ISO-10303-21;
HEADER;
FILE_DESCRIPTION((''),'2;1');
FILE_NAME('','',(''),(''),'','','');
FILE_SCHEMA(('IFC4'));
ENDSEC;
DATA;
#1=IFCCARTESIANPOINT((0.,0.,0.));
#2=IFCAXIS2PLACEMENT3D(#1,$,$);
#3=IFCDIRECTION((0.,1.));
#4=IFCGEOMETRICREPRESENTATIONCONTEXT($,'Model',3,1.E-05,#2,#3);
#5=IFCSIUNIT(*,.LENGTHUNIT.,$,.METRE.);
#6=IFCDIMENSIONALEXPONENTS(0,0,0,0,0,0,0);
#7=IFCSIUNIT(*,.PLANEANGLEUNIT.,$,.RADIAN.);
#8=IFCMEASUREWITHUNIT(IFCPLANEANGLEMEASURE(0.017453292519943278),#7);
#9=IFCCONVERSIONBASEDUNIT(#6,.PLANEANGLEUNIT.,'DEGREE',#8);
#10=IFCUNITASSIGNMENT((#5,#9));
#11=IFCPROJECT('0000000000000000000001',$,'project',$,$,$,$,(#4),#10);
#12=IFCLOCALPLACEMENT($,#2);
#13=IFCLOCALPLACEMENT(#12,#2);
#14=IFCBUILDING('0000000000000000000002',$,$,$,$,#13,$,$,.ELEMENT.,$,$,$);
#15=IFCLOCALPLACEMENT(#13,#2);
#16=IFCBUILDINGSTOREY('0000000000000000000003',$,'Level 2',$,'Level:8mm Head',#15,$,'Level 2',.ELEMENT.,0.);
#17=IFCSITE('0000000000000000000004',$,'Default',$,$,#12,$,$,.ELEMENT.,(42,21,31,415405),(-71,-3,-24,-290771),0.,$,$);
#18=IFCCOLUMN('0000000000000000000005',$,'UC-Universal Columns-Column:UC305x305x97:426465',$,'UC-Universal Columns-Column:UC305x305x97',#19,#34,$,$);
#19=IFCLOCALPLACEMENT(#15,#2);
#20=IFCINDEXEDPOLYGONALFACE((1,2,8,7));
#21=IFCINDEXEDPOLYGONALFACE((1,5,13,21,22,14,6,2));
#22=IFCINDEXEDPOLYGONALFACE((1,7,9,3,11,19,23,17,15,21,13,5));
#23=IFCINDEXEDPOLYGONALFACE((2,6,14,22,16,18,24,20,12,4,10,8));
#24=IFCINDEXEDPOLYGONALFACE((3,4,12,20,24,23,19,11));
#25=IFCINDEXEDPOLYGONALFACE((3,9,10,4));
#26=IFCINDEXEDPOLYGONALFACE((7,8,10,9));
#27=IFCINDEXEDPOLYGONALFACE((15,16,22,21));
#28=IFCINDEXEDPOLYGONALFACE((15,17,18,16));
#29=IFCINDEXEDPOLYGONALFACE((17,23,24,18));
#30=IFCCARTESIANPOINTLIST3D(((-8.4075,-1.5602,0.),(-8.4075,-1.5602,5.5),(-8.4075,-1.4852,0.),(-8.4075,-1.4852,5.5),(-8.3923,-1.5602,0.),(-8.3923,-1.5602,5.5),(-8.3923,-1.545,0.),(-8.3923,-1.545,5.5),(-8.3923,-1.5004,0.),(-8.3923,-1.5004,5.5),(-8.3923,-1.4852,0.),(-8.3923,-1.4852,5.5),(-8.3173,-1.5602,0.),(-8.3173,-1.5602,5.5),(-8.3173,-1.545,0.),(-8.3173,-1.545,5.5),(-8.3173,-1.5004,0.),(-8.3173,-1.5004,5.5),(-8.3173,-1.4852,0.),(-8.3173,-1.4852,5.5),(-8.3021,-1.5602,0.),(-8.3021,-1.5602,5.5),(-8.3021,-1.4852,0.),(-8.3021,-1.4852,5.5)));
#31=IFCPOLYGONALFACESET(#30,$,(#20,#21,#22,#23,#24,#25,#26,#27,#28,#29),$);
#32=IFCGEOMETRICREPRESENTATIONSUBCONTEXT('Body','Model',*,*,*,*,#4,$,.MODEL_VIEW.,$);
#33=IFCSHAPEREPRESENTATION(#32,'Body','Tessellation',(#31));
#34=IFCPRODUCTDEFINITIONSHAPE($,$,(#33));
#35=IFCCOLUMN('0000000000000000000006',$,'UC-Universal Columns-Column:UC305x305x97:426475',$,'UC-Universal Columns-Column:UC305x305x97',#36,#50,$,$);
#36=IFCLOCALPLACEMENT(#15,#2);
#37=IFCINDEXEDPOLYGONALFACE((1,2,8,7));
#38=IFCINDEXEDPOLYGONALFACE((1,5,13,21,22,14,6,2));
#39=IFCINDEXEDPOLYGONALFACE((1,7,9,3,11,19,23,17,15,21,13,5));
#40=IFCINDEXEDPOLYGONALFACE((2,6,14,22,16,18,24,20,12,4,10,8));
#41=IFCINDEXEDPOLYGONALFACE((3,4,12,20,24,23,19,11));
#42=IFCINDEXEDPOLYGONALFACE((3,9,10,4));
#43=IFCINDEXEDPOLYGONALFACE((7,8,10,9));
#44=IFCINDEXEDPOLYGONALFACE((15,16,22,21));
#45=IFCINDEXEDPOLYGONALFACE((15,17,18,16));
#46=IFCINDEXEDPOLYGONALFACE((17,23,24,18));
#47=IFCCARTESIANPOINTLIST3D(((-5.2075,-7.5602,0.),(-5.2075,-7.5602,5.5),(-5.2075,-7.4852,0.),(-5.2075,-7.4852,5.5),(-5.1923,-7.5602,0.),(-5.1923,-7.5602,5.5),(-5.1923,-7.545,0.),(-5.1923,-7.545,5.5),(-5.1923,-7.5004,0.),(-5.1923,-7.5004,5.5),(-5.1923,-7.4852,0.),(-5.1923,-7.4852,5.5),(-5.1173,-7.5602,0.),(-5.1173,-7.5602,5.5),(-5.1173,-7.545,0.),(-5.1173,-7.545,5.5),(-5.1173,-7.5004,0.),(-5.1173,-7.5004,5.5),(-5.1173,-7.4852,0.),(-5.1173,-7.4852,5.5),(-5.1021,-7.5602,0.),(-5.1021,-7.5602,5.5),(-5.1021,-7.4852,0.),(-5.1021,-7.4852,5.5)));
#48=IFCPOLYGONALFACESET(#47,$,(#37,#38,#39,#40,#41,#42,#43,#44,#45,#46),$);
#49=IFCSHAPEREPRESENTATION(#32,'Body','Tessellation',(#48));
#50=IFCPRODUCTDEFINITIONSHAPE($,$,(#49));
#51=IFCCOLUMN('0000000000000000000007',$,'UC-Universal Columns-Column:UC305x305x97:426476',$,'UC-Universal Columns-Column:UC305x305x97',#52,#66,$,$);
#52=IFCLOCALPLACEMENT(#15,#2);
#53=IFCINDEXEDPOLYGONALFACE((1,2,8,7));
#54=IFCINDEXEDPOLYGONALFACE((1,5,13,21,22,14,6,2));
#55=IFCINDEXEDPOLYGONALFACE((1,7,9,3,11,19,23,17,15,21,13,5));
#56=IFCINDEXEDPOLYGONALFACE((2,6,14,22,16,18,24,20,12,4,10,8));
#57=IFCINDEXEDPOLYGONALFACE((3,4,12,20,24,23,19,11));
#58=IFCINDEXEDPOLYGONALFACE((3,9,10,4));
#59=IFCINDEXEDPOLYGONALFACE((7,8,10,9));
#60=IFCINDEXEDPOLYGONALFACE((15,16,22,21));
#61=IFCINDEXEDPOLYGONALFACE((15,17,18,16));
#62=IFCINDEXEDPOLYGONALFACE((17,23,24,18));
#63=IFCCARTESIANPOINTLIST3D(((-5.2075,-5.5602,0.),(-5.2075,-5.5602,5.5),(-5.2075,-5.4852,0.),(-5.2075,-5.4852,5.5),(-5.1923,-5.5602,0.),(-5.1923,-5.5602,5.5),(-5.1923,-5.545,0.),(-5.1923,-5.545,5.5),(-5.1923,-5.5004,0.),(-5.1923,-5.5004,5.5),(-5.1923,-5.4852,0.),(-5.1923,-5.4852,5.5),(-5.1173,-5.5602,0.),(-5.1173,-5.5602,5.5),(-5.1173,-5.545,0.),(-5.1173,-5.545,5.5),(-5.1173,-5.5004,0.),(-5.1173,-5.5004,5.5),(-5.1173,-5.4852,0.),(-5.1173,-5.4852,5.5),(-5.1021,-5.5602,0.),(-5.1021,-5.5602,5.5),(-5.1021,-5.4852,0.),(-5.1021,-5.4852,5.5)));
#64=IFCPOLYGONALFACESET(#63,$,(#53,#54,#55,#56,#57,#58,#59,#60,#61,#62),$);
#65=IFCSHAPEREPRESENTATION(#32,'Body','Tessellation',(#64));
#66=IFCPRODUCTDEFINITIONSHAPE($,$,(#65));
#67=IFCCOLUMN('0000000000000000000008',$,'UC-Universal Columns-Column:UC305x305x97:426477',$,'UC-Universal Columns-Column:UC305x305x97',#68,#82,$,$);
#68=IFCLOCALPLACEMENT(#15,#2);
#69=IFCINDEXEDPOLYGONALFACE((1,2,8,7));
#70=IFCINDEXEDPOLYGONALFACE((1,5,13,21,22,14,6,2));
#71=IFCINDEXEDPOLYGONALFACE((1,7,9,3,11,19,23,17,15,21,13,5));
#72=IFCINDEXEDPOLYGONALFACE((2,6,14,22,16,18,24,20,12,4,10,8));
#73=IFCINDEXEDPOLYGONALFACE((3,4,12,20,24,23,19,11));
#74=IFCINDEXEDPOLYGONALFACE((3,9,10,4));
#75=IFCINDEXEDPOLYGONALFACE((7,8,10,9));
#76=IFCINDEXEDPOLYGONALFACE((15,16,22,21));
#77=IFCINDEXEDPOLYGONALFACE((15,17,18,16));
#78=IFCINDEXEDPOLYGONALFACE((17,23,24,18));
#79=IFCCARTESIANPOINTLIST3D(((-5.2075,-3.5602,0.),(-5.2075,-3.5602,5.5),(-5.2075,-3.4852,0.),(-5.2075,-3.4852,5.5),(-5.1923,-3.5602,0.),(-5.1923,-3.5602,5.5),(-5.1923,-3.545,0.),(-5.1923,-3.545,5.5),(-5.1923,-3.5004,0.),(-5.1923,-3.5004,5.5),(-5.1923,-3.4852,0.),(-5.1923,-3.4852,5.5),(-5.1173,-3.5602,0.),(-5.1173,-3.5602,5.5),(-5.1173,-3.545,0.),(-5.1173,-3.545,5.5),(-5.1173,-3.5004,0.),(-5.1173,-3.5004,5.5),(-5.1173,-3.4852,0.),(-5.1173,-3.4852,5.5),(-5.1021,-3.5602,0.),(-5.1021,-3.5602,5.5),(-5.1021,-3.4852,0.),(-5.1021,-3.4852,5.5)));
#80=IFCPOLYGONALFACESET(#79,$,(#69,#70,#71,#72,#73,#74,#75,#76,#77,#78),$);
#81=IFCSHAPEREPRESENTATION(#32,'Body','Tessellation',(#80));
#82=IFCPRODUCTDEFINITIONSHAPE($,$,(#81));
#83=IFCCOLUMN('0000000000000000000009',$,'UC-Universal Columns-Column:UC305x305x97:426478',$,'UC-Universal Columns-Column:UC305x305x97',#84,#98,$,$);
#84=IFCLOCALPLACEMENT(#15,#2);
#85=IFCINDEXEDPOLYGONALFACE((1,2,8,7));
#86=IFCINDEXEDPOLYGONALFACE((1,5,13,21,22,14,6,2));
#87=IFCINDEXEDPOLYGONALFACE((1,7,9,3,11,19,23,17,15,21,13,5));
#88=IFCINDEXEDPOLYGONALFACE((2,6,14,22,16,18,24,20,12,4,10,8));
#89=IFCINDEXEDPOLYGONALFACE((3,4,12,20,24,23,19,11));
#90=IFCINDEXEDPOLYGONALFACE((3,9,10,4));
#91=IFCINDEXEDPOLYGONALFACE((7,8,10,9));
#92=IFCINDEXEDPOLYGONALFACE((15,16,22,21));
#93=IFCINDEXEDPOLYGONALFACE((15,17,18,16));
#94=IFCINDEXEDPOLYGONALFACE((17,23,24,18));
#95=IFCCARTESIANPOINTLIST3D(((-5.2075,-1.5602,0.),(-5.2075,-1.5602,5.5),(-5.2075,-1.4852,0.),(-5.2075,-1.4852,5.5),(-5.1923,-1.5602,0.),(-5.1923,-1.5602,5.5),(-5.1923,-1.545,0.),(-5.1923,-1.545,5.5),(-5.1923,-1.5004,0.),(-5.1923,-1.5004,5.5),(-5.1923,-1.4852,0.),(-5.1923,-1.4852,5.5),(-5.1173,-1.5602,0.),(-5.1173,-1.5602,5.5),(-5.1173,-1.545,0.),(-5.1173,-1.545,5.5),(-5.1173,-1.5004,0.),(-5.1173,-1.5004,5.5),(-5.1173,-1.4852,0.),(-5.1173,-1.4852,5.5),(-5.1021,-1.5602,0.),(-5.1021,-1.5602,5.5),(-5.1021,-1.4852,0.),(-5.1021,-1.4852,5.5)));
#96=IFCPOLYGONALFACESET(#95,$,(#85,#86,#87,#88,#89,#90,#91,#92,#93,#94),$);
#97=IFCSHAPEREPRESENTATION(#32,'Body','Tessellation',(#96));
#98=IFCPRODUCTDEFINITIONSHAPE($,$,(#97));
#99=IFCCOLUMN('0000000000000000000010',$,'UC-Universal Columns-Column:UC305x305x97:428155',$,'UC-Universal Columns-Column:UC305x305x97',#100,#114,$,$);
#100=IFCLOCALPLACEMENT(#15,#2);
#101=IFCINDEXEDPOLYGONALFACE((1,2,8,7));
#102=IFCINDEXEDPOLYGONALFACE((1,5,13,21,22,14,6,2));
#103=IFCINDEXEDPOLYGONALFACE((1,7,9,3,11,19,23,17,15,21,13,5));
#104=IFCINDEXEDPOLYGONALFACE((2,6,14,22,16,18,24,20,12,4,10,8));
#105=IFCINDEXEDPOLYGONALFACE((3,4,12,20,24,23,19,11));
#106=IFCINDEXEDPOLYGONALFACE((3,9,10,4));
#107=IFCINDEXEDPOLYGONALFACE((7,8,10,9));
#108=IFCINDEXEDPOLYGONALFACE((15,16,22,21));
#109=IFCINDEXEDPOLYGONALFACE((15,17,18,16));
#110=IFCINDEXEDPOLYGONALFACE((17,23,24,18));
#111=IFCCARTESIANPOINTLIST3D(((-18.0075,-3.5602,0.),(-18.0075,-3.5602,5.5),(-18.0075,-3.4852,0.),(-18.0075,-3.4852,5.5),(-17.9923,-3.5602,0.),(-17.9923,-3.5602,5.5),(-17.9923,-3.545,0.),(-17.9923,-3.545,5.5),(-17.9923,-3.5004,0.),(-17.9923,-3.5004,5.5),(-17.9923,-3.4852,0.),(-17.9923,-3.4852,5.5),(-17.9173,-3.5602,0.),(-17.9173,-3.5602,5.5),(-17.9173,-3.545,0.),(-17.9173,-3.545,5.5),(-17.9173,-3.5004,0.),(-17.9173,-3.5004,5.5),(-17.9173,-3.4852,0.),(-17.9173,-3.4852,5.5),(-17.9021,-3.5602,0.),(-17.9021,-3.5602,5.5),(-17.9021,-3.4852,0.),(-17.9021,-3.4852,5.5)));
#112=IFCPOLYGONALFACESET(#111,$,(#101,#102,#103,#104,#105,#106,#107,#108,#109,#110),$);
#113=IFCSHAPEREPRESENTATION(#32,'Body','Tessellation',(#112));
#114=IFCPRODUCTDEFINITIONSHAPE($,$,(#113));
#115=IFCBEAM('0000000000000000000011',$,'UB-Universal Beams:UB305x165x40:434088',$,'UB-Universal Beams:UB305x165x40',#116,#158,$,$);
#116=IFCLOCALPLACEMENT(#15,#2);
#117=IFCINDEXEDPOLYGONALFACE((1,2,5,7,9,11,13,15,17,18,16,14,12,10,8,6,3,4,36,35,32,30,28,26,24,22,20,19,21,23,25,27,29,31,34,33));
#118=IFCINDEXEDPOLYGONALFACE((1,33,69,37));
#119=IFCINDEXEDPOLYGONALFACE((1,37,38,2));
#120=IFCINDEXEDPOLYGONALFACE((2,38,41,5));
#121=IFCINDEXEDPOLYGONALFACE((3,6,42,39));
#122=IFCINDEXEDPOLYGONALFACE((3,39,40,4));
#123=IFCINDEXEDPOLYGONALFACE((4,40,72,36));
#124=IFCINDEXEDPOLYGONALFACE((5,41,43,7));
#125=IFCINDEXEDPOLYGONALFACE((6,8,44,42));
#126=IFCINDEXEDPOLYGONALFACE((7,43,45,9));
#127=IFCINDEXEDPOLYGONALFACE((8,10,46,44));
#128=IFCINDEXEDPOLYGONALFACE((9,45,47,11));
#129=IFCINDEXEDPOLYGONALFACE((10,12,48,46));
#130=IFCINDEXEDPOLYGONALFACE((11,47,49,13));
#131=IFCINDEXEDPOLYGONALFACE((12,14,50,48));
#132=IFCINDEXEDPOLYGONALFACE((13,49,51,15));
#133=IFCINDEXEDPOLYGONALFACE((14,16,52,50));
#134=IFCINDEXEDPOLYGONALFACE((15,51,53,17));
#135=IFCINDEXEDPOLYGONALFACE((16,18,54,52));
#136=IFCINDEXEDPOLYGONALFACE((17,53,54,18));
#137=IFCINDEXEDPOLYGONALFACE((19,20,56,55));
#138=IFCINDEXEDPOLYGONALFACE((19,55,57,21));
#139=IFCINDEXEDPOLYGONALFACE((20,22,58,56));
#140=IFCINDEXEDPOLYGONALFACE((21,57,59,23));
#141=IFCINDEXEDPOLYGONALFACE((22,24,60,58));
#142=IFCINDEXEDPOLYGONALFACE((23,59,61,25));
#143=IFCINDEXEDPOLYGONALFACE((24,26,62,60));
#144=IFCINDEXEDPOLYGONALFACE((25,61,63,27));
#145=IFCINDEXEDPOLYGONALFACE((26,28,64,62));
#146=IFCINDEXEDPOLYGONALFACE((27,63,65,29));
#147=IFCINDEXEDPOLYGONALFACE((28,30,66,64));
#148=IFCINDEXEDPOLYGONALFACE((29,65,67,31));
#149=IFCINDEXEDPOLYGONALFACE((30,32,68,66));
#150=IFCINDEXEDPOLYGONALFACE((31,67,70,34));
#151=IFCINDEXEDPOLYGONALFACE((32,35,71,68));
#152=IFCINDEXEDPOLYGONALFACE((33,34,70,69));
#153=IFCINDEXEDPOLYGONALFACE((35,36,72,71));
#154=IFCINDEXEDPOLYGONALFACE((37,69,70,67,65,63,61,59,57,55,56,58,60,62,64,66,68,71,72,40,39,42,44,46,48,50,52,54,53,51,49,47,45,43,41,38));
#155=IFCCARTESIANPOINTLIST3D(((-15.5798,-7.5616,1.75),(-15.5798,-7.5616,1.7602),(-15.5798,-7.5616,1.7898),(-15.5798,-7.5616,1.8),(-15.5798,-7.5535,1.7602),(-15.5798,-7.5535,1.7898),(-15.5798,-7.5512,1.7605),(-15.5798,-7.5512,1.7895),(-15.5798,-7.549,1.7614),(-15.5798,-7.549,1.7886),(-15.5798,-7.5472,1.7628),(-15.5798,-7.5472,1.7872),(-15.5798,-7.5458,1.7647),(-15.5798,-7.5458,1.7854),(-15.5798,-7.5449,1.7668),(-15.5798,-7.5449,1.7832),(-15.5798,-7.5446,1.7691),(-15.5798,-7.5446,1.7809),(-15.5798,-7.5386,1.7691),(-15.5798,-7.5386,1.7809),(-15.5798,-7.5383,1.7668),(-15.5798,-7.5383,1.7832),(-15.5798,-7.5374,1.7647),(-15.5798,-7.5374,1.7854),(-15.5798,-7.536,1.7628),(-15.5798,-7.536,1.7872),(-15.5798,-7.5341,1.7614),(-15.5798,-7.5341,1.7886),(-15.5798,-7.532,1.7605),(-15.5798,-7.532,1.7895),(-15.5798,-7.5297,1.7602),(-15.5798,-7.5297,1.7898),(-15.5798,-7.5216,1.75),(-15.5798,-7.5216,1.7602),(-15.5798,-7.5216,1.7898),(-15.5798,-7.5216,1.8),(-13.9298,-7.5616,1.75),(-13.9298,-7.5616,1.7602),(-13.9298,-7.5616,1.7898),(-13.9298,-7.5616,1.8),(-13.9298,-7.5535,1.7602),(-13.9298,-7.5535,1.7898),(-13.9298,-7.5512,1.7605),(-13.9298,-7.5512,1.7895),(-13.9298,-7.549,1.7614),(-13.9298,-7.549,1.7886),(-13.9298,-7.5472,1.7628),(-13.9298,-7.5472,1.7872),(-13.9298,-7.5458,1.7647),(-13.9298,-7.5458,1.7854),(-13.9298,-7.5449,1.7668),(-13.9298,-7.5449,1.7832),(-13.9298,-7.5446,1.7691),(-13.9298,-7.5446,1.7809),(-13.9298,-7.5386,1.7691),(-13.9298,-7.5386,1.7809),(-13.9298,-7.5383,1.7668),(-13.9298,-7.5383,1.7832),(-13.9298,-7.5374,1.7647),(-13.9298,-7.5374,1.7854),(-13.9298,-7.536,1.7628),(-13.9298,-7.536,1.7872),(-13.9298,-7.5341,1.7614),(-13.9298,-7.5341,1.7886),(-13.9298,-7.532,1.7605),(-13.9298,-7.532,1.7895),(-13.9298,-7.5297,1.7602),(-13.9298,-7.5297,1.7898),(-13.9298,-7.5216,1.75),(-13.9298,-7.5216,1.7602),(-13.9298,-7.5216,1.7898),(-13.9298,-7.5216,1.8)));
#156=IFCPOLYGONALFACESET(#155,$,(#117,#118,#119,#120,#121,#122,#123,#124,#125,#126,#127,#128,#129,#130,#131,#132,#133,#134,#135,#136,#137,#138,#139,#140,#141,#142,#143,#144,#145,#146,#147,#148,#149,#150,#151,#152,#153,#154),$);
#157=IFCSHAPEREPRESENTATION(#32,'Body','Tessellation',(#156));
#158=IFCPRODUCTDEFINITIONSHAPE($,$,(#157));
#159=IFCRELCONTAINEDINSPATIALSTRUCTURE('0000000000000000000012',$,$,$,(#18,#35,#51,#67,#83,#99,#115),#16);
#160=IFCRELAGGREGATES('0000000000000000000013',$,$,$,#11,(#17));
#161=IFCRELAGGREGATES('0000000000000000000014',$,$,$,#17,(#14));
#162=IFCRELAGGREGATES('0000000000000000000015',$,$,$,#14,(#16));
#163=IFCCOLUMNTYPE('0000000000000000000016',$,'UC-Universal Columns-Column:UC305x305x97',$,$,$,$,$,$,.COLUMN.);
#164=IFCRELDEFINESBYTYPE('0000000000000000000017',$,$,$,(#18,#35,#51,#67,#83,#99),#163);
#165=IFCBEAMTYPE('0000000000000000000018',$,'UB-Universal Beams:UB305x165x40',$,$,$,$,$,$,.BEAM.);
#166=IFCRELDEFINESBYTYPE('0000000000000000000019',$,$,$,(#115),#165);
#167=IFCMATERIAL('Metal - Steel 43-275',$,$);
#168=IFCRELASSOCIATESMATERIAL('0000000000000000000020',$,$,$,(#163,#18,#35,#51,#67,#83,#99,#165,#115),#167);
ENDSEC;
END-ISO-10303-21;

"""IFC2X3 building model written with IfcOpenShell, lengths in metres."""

from ifc_helpers import new_model, entity, si_unit, converted_unit, direction, frame, frame_2d, origin, place, context, subcontext, project, spatial, polyline, circle_curve, parameter, trimmed, segment, composite_curve, i_section, outline, extrude, source, transform, mapped, material, type_object, type_shapes, element, save


model = new_model("IFC2X3")

# Units and contexts
model_context = context("Model", 3, precision=1e-05, world=origin(), true_north=direction((0.0, 1.0)))
body_context = subcontext(model_context, "Body", "Model", "MODEL_VIEW")
ifc_project = project(units=[si_unit("LENGTHUNIT", "METRE"), converted_unit("PLANEANGLEUNIT", "DEGREE", entity("IfcPlaneAngleMeasure", 0.017453292519943278), si_unit("PLANEANGLEUNIT", "RADIAN"), dimensions=[0, 0, 0, 0, 0, 0, 0])], contexts=[model_context])

# Site, building, storey
site_placement = place(None, origin())
site = spatial("IfcSite", under=ifc_project, at=site_placement, Name="Default", CompositionType="ELEMENT", RefLatitude=(42, 21, 31, 415405), RefLongitude=(-71, -3, -24, -290771), RefElevation=0.0)
building_placement = place(site_placement, origin())
building = spatial("IfcBuilding", under=site, at=building_placement, CompositionType="ELEMENT")
storey_placement = place(building_placement, origin())
storey = spatial("IfcBuildingStorey", under=building, at=storey_placement, Name="Level 2", ObjectType="Level:8mm Head", LongName="Level 2", CompositionType="ELEMENT", Elevation=0.0)

# Columns
ifc_material = material(Name="Metal - Steel 43-275")
column_type = type_object("IfcColumnType", Name="UC-Universal Columns-Column:UC305x305x97", PredefinedType="COLUMN", material=ifc_material)
shared_shape = source(origin(), body_context, "Body", "SweptSolid", [
    extrude(outline(composite_curve([segment(polyline([(-0.0375, -0.0375), (0.0375, -0.0375)]), True, "CONTINUOUS"), segment(polyline([(0.0375, -0.0375), (0.0527, -0.0375)]), True, "CONTINUOUS"), segment(trimmed(circle_curve(frame_2d((0.0527, -0.0223), x_axis=(-1.0, 0.0)), 0.0152), [parameter(0.0)], [parameter(90.0)], True, "PARAMETER"), False, "CONTINUOUS"), segment(polyline([(0.0375, -0.0223), (0.0375, 0.0223)]), True, "CONTINUOUS"), segment(trimmed(circle_curve(frame_2d((0.0527, 0.0223), x_axis=(-1.0, 0.0)), 0.0152), [parameter(270.0)], [parameter(0.0)], True, "PARAMETER"), False, "CONTINUOUS"), segment(polyline([(0.0527, 0.0375), (0.0375, 0.0375)]), True, "CONTINUOUS"), segment(polyline([(0.0375, 0.0375), (-0.0375, 0.0375)]), True, "CONTINUOUS"), segment(polyline([(-0.0375, 0.0375), (-0.0527, 0.0375)]), True, "CONTINUOUS"), segment(trimmed(circle_curve(frame_2d((-0.0527, 0.0223), x_axis=(-1.0, 0.0)), 0.0152), [parameter(180.0)], [parameter(270.0)], True, "PARAMETER"), False, "CONTINUOUS"), segment(polyline([(-0.0375, 0.0223), (-0.0375, -0.0223)]), True, "CONTINUOUS"), segment(trimmed(circle_curve(frame_2d((-0.0527, -0.0223), x_axis=(-1.0, 0.0)), 0.0152), [parameter(90.0)], [parameter(180.0)], True, "PARAMETER"), False, "CONTINUOUS"), segment(polyline([(-0.0527, -0.0375), (-0.0375, -0.0375)]), True, "CONTINUOUS")], self_intersect=False)), frame((0.0, 0.0, 0.0), z_axis=(0.0, 0.0, 1.0), x_axis=(-1.0, 0.0, 0.0)), (0.0, 0.0, 1.0), 5.5),
])
type_shapes(column_type, [shared_shape])
for number, where, z_axis, x_axis, name in (
    (1, (-8.3548, -1.5227, 0.0), (0.0, 0.0, 1.0), (-1.0, 0.0, 0.0), "UC-Universal Columns-Column:UC305x305x97:426465"),
    (2, (-5.1548, -7.5227, 0.0), (0.0, 0.0, 1.0), (-1.0, 0.0, 0.0), "UC-Universal Columns-Column:UC305x305x97:426475"),
    (3, (-5.1548, -5.5227, 0.0), (0.0, 0.0, 1.0), (-1.0, 0.0, 0.0), "UC-Universal Columns-Column:UC305x305x97:426476"),
    (4, (-5.1548, -3.5227, 0.0), (0.0, 0.0, 1.0), (-1.0, 0.0, 0.0), "UC-Universal Columns-Column:UC305x305x97:426477"),
    (5, (-5.1548, -1.5227, 0.0), (0.0, 0.0, 1.0), (-1.0, 0.0, 0.0), "UC-Universal Columns-Column:UC305x305x97:426478"),
):
    element("IfcColumn", number, at=place(storey_placement, frame(where, z_axis=z_axis, x_axis=x_axis)), inside=storey, type_object=column_type, material=ifc_material, Name=name, ObjectType="UC-Universal Columns-Column:UC305x305x97", context=body_context, shape_type="MappedRepresentation", body=[
        mapped(shared_shape, transform((0.0, 0.0, 0.0), scale=1.0)),
    ])
column_placement = place(storey_placement, frame((-17.9548, -3.5227, 0.0)))
element("IfcColumn", 6, at=column_placement, inside=storey, type_object=column_type, material=ifc_material, Name="UC-Universal Columns-Column:UC305x305x97:428155", ObjectType="UC-Universal Columns-Column:UC305x305x97", context=body_context, shape_type="MappedRepresentation", body=[
    mapped(shared_shape, transform((0.0, 0.0, 0.0), scale=1.0)),
])

# Beam
beam_type = type_object("IfcBeamType", Name="UB-Universal Beams:UB305x165x40", PredefinedType="BEAM", material=ifc_material)
for number, where, name in (
    (7, (-15.5798, -7.5416, 1.8), "UB-Universal Beams:UB305x165x40:434088"),
):
    element("IfcBeam", number, at=place(storey_placement, frame(where)), inside=storey, type_object=beam_type, material=ifc_material, Name=name, ObjectType="UB-Universal Beams:UB305x165x40", context=body_context, shape_type="SweptSolid", body=[
        extrude(i_section(OverallWidth=0.04, OverallDepth=0.05, WebThickness=0.006, FlangeThickness=0.0102, FilletRadius=0.0089, at=frame_2d((0.0, 0.0), x_axis=(0.0, 1.0))), frame((0.0, 0.0, -0.025), z_axis=(1.0, 0.0, 0.0), x_axis=(0.0, 0.0, -1.0)), (0.0, 0.0, 1.0), 1.65),
    ])

save(model, "model.ifc")
